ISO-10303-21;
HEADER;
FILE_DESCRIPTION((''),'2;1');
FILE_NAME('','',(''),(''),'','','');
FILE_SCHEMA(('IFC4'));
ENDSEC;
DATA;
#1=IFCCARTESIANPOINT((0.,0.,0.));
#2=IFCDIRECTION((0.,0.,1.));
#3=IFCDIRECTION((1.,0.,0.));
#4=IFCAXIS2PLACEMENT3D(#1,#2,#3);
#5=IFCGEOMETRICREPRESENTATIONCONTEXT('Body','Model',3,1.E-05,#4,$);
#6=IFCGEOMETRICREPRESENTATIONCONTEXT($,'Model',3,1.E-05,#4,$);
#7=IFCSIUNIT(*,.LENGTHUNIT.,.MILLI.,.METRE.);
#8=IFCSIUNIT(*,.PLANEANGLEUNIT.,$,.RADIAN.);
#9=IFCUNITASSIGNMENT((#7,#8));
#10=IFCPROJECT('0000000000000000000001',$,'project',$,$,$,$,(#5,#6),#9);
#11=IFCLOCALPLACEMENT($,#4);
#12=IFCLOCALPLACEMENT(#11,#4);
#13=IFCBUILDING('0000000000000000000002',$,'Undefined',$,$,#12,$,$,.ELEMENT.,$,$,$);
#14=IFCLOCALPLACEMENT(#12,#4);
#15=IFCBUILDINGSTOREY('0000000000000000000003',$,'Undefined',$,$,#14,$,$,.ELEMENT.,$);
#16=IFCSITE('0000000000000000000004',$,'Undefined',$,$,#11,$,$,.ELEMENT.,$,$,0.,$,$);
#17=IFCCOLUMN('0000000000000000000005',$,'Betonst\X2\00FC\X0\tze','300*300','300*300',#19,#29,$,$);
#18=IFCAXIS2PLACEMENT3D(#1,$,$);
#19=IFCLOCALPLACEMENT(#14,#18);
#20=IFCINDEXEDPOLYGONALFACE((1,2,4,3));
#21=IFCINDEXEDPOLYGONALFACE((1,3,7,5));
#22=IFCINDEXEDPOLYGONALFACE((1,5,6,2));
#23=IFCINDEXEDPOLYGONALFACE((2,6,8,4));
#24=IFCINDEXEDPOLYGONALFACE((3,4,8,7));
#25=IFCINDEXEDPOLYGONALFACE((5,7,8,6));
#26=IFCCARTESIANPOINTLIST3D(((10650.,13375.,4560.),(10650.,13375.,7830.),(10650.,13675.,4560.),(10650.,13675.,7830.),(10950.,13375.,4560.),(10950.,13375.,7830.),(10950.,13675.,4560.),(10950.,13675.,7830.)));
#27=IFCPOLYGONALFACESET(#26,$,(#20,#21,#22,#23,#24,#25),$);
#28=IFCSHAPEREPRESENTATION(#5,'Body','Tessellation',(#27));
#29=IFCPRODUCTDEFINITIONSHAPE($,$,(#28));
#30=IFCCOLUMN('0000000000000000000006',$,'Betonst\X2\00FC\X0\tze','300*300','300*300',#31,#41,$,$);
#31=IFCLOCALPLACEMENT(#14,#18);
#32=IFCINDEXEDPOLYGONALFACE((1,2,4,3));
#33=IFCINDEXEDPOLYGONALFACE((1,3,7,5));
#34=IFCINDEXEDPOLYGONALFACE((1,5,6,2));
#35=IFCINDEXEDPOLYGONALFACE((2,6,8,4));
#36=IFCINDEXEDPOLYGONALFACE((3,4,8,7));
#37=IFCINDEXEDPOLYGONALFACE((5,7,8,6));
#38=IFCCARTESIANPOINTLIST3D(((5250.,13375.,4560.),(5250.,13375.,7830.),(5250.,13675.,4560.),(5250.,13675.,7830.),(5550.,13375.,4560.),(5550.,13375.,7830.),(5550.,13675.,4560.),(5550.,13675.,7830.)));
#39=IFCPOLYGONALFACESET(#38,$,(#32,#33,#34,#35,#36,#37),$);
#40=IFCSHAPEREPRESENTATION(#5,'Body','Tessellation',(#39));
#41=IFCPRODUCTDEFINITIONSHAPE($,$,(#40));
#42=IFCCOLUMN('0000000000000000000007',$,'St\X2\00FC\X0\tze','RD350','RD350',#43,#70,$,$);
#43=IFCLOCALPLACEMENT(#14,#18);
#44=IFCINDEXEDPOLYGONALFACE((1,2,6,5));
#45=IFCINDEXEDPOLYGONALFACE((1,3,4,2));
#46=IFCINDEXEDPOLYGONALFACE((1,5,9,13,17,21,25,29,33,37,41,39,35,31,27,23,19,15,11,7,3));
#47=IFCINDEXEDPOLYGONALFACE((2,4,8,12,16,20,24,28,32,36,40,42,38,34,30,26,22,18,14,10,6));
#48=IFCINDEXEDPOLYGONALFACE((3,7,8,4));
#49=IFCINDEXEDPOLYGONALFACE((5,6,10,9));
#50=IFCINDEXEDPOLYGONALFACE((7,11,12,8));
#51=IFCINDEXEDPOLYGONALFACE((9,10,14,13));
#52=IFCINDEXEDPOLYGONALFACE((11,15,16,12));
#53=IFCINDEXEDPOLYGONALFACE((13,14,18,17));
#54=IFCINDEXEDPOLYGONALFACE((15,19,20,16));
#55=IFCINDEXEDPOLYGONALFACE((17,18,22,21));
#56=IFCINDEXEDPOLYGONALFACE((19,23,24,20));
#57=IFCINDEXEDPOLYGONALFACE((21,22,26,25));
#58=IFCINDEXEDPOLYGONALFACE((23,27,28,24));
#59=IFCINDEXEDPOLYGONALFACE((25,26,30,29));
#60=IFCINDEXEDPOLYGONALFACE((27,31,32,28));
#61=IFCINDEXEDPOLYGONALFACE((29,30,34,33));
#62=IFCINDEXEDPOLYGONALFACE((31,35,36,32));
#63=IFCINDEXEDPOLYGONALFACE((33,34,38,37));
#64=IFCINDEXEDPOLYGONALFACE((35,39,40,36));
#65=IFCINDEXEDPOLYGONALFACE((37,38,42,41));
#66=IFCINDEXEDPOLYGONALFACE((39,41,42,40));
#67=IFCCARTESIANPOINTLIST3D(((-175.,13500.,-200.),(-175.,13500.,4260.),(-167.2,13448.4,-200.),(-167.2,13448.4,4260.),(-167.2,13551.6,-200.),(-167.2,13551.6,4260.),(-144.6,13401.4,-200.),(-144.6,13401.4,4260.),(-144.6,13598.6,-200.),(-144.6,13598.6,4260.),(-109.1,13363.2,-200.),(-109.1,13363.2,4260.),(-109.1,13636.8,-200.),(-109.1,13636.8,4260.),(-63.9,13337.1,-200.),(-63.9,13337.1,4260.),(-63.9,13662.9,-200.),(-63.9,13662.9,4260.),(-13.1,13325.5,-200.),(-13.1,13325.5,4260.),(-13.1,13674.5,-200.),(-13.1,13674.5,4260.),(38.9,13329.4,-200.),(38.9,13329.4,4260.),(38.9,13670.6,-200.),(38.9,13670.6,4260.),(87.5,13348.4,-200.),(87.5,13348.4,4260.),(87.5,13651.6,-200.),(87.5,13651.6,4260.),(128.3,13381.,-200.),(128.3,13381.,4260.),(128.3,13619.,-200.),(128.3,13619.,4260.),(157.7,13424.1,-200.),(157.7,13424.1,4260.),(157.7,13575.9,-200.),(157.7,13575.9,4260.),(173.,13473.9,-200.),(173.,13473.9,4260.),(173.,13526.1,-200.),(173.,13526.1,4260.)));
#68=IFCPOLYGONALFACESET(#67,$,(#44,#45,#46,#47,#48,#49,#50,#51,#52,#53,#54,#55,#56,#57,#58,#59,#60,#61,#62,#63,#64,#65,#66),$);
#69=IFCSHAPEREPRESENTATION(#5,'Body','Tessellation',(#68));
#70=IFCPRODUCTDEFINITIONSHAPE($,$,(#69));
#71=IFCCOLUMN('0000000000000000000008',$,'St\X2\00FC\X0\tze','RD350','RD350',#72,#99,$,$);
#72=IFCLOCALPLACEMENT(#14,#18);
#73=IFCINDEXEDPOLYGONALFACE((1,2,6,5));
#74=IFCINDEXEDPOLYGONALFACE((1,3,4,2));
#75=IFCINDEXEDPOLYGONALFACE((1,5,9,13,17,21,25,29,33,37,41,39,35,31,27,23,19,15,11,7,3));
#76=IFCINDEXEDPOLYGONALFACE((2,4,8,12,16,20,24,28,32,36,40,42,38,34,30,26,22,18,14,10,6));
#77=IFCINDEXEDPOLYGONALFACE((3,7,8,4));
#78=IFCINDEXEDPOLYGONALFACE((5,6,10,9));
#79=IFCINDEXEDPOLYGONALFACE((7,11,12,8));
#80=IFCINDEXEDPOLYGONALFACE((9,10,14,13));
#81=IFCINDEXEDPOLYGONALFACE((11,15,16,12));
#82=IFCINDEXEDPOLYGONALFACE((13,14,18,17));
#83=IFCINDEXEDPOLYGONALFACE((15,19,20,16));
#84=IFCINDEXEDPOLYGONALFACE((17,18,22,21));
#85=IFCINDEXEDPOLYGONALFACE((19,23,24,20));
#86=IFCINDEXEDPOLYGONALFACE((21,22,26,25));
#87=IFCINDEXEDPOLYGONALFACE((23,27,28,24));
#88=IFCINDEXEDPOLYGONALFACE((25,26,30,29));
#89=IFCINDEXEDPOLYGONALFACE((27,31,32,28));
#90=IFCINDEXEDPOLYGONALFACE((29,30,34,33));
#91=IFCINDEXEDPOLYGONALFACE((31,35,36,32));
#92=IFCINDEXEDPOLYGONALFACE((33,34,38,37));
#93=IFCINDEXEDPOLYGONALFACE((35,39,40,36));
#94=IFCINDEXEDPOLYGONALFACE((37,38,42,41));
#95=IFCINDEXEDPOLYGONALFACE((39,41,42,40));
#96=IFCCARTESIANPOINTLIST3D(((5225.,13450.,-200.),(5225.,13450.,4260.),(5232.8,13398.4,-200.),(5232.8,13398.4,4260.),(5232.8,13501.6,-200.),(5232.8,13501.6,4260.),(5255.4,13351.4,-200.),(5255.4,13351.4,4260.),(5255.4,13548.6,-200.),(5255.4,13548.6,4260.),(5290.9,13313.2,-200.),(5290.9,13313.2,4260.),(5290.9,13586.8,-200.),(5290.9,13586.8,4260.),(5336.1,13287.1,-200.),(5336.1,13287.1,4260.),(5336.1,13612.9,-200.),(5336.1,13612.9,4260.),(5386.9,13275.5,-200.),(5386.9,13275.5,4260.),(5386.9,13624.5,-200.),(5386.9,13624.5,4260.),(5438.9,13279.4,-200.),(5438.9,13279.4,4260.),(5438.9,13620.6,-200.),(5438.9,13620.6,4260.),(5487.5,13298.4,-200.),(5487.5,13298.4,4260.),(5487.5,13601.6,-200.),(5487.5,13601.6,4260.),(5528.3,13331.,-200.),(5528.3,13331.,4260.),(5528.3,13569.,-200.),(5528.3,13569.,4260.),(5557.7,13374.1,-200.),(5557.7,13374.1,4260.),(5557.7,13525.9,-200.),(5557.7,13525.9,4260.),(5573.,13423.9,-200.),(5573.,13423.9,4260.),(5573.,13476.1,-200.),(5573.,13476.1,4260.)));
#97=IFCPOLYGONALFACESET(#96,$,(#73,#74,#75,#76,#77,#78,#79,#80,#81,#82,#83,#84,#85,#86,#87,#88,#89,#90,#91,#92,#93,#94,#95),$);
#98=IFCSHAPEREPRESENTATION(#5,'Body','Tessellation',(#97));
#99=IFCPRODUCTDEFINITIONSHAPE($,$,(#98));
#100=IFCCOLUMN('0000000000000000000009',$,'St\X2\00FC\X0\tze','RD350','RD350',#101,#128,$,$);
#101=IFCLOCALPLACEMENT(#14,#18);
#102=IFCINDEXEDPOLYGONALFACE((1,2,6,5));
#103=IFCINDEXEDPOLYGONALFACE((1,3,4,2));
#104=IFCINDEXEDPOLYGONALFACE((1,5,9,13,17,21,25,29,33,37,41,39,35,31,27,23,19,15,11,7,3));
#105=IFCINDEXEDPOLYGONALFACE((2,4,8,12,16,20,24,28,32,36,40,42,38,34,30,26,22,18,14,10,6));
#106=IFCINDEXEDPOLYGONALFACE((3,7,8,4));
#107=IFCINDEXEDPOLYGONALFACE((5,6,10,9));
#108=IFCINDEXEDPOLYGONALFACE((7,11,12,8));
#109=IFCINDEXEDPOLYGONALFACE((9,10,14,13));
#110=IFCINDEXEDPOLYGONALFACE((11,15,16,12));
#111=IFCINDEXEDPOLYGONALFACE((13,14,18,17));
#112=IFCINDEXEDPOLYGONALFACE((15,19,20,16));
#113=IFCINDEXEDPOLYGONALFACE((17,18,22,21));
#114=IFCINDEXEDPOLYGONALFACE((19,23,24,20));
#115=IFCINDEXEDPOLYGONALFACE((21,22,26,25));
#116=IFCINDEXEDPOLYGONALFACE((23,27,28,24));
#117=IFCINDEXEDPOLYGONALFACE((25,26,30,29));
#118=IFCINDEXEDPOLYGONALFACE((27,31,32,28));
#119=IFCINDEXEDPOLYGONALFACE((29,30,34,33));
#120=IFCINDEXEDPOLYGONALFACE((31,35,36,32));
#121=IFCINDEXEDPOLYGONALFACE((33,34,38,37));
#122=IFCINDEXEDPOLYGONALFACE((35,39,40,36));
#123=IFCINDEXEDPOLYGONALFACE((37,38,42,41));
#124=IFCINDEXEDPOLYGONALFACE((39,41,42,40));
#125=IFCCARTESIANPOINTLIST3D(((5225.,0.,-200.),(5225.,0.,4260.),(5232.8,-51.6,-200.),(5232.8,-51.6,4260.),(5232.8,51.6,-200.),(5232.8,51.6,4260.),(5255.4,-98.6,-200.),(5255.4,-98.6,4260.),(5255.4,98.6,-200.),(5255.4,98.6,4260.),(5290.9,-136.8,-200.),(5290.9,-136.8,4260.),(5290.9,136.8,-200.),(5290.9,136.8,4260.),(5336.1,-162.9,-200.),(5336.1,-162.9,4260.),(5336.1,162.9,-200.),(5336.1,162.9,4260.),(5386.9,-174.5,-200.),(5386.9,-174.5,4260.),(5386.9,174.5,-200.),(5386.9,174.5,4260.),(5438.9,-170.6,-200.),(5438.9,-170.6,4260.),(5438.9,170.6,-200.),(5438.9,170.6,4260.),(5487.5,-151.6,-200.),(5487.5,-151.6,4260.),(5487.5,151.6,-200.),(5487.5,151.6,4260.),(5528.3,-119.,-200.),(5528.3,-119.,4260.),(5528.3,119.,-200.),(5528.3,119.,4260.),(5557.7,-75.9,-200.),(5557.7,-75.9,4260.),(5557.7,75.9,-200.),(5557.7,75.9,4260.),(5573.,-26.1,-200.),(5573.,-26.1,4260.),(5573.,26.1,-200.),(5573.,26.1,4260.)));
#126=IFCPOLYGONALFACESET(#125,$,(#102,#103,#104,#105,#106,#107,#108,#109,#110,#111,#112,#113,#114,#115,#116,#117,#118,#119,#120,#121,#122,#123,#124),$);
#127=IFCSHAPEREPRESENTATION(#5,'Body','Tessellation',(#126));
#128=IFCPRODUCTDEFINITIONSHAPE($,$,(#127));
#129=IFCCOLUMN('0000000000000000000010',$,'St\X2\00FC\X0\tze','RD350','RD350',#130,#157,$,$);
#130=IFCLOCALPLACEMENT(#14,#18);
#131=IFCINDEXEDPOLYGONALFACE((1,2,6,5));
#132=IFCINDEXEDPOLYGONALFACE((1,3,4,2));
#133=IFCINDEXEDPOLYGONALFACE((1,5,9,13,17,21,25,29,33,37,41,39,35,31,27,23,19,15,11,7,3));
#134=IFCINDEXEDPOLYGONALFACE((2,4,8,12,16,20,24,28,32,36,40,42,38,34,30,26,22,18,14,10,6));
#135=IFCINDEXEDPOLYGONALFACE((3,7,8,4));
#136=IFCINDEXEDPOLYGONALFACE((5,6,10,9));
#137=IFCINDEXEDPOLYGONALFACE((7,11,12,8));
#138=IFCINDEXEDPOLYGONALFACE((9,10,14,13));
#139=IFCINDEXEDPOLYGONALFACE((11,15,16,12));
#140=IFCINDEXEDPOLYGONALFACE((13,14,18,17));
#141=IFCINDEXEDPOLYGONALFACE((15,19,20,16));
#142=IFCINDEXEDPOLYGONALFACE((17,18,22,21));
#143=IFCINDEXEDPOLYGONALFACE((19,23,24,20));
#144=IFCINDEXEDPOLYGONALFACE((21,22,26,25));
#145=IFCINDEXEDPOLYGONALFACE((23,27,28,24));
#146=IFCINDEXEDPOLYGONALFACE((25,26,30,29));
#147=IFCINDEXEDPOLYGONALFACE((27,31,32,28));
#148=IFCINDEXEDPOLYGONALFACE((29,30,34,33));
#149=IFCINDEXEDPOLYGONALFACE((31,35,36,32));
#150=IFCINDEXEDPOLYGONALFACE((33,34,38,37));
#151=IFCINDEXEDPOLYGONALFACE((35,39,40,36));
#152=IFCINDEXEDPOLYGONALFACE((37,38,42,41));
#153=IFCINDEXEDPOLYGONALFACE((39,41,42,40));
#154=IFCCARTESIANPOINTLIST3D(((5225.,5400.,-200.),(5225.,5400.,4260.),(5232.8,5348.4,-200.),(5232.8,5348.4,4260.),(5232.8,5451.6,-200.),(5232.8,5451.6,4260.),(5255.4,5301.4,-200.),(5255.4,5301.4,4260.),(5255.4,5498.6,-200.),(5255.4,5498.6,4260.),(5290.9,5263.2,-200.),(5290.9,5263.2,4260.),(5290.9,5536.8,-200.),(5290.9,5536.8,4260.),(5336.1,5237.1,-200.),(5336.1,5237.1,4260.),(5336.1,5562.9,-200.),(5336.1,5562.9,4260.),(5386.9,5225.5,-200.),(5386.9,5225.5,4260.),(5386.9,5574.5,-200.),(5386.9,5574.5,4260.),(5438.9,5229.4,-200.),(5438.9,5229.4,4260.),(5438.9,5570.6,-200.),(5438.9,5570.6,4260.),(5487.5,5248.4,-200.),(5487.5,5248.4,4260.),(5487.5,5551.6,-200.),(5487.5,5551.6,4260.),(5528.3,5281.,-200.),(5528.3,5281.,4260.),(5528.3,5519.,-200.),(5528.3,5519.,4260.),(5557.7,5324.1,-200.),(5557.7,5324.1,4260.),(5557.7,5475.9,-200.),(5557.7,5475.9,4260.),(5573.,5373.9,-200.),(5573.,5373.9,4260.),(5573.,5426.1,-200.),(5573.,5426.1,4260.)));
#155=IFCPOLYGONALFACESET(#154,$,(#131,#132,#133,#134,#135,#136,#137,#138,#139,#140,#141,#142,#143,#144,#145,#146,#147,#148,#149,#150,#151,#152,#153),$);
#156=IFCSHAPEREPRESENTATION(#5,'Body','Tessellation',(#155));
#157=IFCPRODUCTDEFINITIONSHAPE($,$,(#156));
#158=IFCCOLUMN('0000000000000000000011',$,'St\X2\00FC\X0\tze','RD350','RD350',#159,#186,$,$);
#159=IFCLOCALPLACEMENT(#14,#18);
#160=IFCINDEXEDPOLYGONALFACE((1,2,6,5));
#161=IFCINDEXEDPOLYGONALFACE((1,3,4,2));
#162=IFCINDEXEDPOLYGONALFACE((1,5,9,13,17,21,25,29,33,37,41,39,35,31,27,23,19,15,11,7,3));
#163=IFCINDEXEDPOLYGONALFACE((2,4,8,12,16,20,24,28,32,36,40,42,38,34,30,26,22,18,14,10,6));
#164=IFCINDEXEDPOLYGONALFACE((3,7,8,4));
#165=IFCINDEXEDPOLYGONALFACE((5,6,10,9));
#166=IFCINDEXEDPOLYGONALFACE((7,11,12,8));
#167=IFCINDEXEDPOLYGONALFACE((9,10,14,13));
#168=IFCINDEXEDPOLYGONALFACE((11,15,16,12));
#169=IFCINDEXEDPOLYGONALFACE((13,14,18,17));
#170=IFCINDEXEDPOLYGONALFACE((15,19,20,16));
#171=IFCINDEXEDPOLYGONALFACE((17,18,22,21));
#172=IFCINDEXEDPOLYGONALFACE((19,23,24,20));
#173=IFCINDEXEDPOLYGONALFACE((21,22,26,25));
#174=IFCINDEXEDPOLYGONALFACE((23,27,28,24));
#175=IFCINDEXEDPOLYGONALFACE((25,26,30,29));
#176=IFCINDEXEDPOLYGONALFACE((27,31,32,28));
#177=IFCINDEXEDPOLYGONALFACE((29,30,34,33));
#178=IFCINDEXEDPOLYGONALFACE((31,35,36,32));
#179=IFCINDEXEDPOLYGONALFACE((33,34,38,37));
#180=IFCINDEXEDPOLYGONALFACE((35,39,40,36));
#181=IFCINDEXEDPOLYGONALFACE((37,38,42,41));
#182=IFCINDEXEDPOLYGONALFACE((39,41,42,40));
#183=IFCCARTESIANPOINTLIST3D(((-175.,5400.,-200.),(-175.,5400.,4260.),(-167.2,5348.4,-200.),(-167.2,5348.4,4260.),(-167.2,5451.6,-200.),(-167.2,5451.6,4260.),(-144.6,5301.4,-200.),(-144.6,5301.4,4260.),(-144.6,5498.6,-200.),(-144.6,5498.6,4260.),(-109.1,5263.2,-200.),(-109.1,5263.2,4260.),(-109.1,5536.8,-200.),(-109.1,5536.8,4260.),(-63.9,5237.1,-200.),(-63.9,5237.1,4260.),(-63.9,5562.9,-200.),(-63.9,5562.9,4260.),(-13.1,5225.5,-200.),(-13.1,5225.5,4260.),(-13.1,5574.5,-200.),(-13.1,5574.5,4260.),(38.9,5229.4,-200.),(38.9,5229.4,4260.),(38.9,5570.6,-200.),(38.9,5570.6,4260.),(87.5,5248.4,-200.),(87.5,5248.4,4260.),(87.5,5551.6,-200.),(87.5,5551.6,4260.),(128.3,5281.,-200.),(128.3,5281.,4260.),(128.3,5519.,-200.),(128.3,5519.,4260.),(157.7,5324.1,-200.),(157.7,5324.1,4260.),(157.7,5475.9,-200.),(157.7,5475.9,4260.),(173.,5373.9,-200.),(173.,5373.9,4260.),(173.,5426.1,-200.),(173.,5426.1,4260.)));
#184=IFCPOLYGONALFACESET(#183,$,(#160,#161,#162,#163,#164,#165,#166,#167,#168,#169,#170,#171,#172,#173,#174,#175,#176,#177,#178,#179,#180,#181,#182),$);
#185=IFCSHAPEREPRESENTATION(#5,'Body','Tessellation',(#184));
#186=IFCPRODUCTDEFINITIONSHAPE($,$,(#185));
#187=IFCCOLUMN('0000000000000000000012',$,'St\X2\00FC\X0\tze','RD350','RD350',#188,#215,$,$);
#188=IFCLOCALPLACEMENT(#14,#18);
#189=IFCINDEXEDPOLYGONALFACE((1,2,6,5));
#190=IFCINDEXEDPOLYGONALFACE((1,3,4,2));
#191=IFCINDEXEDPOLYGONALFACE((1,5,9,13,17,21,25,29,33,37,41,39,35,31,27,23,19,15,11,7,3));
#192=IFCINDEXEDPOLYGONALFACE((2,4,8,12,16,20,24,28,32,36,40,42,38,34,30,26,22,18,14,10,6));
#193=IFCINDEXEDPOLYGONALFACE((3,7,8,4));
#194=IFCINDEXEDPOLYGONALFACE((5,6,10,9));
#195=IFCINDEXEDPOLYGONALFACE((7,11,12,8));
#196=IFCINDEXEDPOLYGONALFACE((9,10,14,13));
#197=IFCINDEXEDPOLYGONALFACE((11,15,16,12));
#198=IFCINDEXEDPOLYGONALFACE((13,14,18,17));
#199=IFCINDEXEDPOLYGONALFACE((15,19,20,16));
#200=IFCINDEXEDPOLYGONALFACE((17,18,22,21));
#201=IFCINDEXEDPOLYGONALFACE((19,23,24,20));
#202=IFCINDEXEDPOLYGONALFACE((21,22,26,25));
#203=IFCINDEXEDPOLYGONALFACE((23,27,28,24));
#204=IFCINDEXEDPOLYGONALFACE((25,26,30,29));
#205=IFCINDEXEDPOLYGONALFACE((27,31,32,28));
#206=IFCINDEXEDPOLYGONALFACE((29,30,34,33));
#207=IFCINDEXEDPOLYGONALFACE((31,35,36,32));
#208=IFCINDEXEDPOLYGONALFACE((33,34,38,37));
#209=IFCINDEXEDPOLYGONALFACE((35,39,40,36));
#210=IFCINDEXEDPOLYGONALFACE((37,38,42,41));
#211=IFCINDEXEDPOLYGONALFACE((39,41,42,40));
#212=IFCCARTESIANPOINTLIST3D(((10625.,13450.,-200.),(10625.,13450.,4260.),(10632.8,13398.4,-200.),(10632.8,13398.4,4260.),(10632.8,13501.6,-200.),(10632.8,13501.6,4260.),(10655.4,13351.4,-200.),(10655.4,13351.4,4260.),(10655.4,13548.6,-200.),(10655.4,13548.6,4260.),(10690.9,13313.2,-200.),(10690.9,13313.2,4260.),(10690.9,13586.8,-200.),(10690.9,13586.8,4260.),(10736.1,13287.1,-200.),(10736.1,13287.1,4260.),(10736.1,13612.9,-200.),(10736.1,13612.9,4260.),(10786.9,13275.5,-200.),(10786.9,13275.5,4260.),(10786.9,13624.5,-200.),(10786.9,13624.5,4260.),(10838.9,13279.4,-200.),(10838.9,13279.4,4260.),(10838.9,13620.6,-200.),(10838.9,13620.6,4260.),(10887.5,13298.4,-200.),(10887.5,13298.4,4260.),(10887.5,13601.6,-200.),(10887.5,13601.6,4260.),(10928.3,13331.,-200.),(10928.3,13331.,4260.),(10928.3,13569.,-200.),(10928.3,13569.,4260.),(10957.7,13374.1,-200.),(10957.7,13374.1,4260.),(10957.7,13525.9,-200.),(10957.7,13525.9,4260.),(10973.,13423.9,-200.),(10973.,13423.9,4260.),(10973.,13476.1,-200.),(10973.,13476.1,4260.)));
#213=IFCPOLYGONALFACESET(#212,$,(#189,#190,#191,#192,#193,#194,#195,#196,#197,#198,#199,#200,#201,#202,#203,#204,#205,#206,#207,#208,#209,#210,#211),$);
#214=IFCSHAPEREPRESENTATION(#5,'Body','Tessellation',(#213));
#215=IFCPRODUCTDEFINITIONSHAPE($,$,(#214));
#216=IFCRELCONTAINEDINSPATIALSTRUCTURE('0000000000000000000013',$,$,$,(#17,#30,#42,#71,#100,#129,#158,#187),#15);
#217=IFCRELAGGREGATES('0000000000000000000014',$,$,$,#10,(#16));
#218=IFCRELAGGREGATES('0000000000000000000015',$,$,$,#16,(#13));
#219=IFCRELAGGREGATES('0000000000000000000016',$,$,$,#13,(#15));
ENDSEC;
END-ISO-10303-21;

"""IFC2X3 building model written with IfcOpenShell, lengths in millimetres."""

from ifc_helpers import new_model, si_unit, frame, origin_with_axes, origin_2d_with_axis, place, context, project, spatial, rectangle, circle, extrude, element, save


model = new_model("IFC2X3")

# Units and contexts
model_context_1 = context("Model", 3, precision=1e-05, world=origin_with_axes(), identifier="Body")
model_context_2 = context("Model", 3, precision=1e-05, world=origin_with_axes())
ifc_project = project(units=[si_unit("LENGTHUNIT", "METRE", prefix="MILLI"), si_unit("PLANEANGLEUNIT", "RADIAN")], contexts=[model_context_1, model_context_2])

# Site, building, storey
site_placement = place(None, origin_with_axes())
site = spatial("IfcSite", under=ifc_project, at=site_placement, Name="Undefined", CompositionType="ELEMENT", RefElevation=0.0)
building_placement = place(site_placement, origin_with_axes())
building = spatial("IfcBuilding", under=site, at=building_placement, Name="Undefined", CompositionType="ELEMENT")
storey_placement = place(building_placement, origin_with_axes())
storey = spatial("IfcBuildingStorey", under=building, at=storey_placement, Name="Undefined", CompositionType="ELEMENT")

# Columns
for number, where, z_axis, x_axis, name in (
    (1, (10800.0, 13525.0, 4560.0), (0.0, 0.0, 1.0), (1.0, 0.0, 0.0), "Betonstütze"),
    (2, (5400.0, 13525.0, 4560.0), (0.0, 0.0, 1.0), (1.0, 0.0, 0.0), "Betonstütze"),
):
    element("IfcColumn", number, at=place(storey_placement, frame(where, z_axis=z_axis, x_axis=x_axis)), inside=storey, Name=name, Description="300*300", ObjectType="300*300", context=model_context_1, shape_type="SweptSolid", body=[
        extrude(rectangle(XDim=300.0, YDim=300.0, at=origin_2d_with_axis()), frame((0.0, 0.0, 3270.0), z_axis=(0.0, 0.0, -1.0), x_axis=(1.0, 0.0, 0.0)), (0.0, 0.0, 1.0), 3270.0),
    ])
for number, where, z_axis, x_axis, name in (
    (3, (0.0, 13500.0, -200.0), (0.0, 0.0, 1.0), (1.0, 0.0, 0.0), "Stütze"),
    (4, (5400.0, 13450.0, -200.0), (0.0, 0.0, 1.0), (1.0, 0.0, 0.0), "Stütze"),
    (5, (5400.0, 0.0, -200.0), (0.0, 0.0, 1.0), (1.0, 0.0, 0.0), "Stütze"),
    (6, (5400.0, 5400.0, -200.0), (0.0, 0.0, 1.0), (1.0, 0.0, 0.0), "Stütze"),
    (7, (0.0, 5400.0, -200.0), (0.0, 0.0, 1.0), (1.0, 0.0, 0.0), "Stütze"),
):
    element("IfcColumn", number, at=place(storey_placement, frame(where, z_axis=z_axis, x_axis=x_axis)), inside=storey, Name=name, Description="RD350", ObjectType="RD350", context=model_context_1, shape_type="SweptSolid", body=[
        extrude(circle(Radius=175.0, at=origin_2d_with_axis()), frame((0.0, 0.0, 4460.0), z_axis=(0.0, 0.0, -1.0), x_axis=(-1.0, 0.0, 0.0)), (0.0, 0.0, 1.0), 4460.0),
    ])

# Column
column_1_placement = place(storey_placement, frame((10800.0, 13450.0, -200.0), z_axis=(0.0, 0.0, 1.0), x_axis=(1.0, 0.0, 0.0)))
element("IfcColumn", 8, at=column_1_placement, inside=storey, Name="Stütze", Description="RD350", ObjectType="RD350", context=model_context_1, shape_type="SweptSolid", body=[
    extrude(circle(Radius=175.0, at=origin_2d_with_axis()), frame((0.0, 0.0, 4460.0), z_axis=(0.0, 0.0, -1.0), x_axis=(-1.0, 0.0, 0.0)), (0.0, 0.0, 1.0), 4460.0),
])

save(model, "model.ifc")
